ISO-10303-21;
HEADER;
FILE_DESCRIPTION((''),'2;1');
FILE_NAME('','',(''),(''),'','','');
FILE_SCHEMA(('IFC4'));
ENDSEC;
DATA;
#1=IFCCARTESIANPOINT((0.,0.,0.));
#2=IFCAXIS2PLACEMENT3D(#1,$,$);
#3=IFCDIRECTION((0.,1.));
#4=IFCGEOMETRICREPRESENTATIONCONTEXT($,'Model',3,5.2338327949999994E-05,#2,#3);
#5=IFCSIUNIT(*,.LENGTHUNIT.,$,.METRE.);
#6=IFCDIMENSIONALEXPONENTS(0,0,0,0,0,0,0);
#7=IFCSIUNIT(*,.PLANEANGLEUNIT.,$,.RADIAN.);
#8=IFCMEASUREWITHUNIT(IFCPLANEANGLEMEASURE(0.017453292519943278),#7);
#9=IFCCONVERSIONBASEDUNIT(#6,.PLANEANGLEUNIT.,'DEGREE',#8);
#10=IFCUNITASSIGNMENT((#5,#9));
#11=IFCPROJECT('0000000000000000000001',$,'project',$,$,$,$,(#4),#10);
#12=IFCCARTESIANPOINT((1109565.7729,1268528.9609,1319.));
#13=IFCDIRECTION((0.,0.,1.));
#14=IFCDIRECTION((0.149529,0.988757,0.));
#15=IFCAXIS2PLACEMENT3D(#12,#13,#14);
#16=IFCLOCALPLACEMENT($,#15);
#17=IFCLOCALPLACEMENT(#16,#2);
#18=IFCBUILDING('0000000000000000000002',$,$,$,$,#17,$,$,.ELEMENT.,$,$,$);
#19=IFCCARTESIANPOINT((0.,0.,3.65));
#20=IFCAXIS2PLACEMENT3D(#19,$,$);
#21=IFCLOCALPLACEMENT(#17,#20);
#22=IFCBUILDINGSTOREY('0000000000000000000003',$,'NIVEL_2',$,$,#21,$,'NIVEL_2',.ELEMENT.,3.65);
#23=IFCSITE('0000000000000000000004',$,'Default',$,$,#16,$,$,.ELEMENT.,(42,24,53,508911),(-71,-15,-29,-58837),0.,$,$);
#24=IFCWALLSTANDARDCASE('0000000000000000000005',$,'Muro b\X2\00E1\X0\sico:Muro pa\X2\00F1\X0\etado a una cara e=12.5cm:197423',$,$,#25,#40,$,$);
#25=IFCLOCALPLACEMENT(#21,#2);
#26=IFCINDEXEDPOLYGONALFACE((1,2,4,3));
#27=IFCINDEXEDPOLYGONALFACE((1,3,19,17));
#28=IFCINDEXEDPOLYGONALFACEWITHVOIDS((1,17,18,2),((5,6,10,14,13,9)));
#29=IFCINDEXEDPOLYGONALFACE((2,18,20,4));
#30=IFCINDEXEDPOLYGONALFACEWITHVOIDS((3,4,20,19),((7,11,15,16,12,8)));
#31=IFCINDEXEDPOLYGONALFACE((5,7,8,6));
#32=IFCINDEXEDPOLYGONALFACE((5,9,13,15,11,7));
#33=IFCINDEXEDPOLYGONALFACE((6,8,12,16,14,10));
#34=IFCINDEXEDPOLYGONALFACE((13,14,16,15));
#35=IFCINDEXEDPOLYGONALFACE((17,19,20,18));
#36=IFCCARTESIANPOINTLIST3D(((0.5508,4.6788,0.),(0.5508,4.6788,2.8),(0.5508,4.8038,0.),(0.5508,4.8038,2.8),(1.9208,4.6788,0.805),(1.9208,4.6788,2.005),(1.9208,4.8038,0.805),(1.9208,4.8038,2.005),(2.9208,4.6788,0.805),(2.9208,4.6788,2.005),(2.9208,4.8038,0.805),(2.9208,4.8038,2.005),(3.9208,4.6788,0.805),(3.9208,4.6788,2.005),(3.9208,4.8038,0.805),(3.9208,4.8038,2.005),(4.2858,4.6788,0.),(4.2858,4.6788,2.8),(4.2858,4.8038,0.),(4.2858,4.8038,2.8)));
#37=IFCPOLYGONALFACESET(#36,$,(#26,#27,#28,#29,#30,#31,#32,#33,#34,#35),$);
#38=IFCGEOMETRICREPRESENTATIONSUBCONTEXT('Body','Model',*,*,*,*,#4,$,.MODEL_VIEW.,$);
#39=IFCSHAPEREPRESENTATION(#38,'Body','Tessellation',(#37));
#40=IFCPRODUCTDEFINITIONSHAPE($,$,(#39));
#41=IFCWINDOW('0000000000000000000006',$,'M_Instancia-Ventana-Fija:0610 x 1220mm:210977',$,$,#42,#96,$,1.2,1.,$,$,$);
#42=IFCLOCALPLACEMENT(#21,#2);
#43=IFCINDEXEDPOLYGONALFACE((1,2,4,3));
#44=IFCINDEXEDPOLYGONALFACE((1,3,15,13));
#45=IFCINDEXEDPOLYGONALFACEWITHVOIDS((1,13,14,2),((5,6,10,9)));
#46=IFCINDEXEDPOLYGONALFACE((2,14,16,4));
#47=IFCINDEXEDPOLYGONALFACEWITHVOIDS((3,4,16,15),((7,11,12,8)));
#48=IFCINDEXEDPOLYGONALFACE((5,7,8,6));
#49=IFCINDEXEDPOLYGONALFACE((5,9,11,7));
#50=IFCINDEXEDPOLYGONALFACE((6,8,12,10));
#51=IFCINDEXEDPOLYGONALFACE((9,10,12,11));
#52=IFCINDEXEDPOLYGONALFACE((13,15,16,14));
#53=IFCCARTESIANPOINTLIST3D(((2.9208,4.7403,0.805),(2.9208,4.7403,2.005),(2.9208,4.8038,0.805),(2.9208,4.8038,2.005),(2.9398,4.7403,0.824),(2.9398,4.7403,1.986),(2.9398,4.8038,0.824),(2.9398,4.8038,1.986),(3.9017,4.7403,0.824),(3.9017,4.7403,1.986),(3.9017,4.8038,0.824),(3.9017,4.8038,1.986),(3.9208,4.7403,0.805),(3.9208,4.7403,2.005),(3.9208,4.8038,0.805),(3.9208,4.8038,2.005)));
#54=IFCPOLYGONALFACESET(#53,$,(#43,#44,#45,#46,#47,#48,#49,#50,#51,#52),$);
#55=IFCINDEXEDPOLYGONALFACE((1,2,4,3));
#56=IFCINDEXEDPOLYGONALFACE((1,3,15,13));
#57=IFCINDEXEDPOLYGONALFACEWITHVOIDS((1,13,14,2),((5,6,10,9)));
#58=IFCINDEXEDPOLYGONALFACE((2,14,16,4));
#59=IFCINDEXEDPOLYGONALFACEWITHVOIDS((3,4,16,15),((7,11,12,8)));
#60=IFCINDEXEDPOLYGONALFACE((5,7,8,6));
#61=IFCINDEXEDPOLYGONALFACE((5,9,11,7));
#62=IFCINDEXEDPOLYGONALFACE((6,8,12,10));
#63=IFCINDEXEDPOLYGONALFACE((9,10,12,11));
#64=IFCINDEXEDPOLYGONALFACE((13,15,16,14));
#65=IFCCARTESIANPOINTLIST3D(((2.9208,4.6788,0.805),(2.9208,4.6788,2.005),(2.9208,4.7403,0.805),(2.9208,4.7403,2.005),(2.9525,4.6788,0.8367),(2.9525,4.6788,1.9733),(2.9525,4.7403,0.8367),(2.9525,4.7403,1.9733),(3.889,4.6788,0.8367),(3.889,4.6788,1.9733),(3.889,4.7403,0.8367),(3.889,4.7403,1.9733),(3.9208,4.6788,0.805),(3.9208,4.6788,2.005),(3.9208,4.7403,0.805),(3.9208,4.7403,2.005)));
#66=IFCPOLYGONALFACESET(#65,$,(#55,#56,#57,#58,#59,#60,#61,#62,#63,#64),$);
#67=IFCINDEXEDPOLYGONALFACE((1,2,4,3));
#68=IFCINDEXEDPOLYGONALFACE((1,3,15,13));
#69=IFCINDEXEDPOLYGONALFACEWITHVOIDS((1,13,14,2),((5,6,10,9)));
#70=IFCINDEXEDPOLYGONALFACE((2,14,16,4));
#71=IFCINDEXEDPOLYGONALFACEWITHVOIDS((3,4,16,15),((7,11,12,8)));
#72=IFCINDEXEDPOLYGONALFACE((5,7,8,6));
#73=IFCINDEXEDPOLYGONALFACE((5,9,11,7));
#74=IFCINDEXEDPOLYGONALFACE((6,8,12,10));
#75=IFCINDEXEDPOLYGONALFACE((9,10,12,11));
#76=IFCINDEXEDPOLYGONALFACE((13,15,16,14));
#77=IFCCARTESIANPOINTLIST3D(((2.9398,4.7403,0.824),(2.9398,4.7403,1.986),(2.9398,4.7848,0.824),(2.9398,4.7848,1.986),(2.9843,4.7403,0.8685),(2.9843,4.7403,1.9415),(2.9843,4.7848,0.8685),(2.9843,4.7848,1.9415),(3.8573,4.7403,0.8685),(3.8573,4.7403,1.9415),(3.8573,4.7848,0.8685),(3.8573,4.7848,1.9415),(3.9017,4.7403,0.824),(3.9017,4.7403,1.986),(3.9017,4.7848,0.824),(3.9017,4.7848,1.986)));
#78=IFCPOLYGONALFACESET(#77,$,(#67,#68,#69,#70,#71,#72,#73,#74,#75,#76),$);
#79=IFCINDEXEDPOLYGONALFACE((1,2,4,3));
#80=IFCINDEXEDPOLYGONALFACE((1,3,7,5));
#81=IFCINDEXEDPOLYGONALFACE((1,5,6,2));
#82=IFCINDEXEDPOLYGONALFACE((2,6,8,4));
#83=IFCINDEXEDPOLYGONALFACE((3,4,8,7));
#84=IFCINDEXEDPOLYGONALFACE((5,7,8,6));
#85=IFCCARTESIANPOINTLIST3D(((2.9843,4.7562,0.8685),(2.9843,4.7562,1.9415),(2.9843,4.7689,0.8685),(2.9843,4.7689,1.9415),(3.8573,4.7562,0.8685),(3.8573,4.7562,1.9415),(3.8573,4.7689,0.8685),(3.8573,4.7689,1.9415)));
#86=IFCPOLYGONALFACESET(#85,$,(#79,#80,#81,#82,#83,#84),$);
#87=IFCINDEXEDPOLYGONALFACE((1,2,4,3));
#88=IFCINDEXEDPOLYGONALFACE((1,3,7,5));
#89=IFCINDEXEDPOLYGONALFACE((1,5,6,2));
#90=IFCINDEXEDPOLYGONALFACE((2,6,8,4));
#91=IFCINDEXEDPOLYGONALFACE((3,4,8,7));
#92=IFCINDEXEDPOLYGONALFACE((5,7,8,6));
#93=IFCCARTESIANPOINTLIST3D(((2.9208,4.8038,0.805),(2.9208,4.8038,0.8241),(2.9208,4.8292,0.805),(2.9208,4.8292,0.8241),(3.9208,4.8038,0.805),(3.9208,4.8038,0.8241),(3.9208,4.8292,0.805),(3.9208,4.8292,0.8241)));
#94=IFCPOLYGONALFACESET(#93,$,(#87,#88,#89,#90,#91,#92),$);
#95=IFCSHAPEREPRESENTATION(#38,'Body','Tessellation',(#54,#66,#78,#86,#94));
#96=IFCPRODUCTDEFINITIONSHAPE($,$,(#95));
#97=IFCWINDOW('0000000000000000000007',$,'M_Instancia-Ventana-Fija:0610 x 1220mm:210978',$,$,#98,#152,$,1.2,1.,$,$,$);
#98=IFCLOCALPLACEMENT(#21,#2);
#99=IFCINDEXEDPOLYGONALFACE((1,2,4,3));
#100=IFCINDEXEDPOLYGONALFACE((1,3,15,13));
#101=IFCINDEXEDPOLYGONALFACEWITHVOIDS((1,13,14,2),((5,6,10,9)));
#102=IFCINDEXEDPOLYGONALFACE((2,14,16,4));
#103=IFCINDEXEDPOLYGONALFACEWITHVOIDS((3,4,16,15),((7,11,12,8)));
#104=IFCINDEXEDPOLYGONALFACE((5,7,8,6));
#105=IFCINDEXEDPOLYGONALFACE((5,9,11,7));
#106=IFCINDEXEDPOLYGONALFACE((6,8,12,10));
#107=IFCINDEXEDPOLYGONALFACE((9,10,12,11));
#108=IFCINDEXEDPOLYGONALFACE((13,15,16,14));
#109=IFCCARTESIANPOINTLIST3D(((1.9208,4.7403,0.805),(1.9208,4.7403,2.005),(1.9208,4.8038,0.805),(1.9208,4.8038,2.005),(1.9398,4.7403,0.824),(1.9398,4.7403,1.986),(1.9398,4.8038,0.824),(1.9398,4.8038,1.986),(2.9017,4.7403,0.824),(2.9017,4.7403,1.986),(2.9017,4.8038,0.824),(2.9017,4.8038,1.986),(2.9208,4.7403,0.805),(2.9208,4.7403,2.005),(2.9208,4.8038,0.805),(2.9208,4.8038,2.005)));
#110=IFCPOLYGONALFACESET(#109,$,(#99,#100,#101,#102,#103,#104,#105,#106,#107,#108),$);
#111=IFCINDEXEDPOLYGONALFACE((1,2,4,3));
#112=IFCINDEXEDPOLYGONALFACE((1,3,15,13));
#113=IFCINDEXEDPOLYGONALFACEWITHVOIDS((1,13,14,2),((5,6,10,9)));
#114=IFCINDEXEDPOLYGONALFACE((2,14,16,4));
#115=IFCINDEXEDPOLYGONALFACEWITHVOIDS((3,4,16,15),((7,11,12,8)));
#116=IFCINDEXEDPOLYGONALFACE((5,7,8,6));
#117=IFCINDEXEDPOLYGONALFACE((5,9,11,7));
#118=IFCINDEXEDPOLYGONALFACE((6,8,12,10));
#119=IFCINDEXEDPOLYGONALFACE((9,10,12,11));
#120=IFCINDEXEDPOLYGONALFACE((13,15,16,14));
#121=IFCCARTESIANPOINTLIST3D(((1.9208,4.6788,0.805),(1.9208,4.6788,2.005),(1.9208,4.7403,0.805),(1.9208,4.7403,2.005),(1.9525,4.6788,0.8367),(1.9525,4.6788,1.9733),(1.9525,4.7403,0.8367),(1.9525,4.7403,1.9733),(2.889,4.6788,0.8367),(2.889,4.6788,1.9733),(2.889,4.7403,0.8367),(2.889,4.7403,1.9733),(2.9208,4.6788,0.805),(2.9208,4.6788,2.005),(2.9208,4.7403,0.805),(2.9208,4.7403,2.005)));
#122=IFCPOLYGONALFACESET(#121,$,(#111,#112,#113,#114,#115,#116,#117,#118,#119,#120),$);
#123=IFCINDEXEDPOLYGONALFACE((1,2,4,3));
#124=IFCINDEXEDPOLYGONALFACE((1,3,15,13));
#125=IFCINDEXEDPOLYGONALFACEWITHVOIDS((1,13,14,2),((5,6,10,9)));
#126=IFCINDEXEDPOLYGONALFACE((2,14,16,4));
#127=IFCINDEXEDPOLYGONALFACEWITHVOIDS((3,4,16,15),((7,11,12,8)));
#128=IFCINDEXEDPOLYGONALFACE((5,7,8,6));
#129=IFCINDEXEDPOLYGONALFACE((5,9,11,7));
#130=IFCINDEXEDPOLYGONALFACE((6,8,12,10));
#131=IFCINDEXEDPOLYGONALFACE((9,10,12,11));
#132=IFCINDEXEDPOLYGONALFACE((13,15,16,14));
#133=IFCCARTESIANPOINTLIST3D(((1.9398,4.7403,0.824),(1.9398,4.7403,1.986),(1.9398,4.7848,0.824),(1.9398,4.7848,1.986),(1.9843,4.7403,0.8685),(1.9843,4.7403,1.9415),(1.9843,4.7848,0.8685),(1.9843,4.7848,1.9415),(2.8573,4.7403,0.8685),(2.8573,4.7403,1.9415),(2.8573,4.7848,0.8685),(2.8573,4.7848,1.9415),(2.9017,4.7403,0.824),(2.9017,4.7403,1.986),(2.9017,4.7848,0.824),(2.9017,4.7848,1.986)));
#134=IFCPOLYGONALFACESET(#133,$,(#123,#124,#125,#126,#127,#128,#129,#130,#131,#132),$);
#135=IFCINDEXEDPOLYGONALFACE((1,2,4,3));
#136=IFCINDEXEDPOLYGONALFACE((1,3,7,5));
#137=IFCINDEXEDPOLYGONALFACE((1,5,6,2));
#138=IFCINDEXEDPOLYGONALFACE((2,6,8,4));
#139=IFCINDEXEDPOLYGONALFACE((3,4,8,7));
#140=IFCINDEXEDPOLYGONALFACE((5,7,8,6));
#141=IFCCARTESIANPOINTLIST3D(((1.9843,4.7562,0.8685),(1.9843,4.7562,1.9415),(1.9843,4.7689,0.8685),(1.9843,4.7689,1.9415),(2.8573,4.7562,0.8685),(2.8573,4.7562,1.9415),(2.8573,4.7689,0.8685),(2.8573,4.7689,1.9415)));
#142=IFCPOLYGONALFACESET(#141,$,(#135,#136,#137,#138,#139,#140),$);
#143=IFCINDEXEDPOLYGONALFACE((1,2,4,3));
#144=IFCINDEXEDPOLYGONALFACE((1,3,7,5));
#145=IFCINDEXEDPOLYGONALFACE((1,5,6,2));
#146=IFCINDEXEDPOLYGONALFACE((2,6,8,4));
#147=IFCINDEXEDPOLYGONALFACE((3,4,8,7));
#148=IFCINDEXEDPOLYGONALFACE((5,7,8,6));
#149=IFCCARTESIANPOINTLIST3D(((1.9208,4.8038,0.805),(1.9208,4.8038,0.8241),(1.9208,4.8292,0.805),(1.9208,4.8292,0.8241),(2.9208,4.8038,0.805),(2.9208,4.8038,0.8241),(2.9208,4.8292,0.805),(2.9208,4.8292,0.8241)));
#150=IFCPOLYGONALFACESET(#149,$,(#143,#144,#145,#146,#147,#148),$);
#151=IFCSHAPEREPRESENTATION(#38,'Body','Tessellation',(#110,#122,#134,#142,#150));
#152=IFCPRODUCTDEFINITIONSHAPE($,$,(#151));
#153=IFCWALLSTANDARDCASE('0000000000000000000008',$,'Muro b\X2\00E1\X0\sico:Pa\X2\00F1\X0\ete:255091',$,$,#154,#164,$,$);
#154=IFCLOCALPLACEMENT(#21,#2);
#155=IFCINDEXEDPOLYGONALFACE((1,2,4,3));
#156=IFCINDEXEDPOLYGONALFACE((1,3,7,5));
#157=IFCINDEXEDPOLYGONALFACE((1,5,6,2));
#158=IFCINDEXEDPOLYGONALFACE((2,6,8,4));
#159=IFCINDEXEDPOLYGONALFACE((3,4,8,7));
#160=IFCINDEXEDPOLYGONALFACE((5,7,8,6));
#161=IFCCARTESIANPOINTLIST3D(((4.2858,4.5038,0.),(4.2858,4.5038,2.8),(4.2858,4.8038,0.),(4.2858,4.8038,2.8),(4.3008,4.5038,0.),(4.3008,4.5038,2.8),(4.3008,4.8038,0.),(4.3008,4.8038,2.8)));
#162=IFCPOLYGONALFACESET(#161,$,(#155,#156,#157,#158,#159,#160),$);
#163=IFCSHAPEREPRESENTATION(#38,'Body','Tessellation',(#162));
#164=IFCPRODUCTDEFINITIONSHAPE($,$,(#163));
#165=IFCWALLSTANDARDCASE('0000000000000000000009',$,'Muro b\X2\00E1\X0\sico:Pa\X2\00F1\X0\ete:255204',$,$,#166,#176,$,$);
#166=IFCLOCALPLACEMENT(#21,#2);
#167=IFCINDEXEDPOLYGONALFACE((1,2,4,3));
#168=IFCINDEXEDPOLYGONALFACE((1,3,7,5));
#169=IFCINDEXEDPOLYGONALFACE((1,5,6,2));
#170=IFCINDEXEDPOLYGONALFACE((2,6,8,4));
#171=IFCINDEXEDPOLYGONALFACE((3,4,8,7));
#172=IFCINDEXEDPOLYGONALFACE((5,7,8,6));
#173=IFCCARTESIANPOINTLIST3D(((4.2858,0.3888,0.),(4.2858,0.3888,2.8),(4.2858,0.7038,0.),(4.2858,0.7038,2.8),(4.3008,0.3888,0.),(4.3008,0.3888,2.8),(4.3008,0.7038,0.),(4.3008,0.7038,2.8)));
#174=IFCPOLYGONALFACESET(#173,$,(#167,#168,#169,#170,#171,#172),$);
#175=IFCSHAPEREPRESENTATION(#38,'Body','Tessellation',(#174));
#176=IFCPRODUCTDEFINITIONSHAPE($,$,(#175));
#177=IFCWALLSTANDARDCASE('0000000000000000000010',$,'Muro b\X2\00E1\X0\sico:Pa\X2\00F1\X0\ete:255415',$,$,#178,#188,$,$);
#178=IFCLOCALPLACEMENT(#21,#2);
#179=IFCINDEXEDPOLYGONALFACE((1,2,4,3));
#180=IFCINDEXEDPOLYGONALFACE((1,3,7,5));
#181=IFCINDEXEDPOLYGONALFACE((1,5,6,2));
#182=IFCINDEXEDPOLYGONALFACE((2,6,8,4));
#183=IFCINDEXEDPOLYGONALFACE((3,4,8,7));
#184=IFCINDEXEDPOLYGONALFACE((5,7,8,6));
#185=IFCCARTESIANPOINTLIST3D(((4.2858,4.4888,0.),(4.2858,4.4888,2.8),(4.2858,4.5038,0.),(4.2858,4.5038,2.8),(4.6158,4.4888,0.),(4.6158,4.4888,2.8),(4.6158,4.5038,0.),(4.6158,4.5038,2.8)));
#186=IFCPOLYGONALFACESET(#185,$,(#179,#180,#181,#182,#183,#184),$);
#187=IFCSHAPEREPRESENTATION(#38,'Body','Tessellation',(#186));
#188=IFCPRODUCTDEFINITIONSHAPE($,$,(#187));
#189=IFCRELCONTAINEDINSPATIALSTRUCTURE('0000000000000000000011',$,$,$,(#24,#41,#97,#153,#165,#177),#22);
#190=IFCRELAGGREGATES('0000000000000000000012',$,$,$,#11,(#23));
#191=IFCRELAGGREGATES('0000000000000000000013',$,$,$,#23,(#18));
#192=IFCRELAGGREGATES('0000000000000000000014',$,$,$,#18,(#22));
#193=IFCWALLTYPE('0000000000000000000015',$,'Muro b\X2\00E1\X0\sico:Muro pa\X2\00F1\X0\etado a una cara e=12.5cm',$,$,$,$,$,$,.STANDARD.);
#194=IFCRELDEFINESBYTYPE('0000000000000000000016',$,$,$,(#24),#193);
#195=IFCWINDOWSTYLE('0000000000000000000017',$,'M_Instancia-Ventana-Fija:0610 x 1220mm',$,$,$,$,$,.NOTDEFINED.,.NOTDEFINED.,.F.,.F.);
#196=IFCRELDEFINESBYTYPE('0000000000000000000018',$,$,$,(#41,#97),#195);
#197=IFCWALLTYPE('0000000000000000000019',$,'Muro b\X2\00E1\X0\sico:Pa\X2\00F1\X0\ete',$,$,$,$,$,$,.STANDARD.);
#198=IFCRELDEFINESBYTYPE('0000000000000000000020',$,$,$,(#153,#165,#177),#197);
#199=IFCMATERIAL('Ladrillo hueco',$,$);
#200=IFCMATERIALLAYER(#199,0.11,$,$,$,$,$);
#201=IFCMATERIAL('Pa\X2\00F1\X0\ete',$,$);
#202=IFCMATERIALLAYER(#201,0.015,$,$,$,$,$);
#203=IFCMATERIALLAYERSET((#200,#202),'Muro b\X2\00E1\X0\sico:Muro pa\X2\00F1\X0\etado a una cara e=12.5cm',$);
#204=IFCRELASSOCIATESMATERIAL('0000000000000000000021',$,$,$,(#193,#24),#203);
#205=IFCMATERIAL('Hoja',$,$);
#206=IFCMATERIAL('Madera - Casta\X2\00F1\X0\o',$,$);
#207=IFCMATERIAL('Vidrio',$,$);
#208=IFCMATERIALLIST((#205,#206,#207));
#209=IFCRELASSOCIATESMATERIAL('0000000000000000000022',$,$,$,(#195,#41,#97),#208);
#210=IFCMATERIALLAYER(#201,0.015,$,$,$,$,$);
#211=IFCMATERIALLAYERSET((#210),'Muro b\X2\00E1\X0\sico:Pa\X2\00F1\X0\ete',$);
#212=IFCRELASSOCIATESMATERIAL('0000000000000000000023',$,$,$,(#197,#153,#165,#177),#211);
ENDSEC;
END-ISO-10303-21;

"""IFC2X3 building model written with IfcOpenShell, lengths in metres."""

from ifc_helpers import new_model, entity, si_unit, converted_unit, direction, frame, frame_2d, origin, origin_2d_with_axis, place, context, subcontext, project, spatial, polyline, rectangle, outline, extrude, source, transform, mapped, material, material_list, layer, layer_set, layer_usage, type_object, type_shapes, element, fill, save


model = new_model("IFC2X3")

# Units and contexts
model_context = context("Model", 3, precision=5.2338327949999994e-05, world=origin(), true_north=direction((0.0, 1.0)))
body_context = subcontext(model_context, "Body", "Model", "MODEL_VIEW")
ifc_project = project(units=[si_unit("LENGTHUNIT", "METRE"), converted_unit("PLANEANGLEUNIT", "DEGREE", entity("IfcPlaneAngleMeasure", 0.017453292519943278), si_unit("PLANEANGLEUNIT", "RADIAN"), dimensions=[0, 0, 0, 0, 0, 0, 0])], contexts=[model_context])

# Site, building, storey
site_placement = place(None, frame((1109565.7729, 1268528.9609, 1319.0), z_axis=(0.0, 0.0, 1.0), x_axis=(0.149529, 0.988757, 0.0)))
site = spatial("IfcSite", under=ifc_project, at=site_placement, Name="Default", CompositionType="ELEMENT", RefLatitude=(42, 24, 53, 508911), RefLongitude=(-71, -15, -29, -58837), RefElevation=0.0)
building_placement = place(site_placement, origin())
building = spatial("IfcBuilding", under=site, at=building_placement, CompositionType="ELEMENT")
storey_placement = place(building_placement, frame((0.0, 0.0, 3.65)))
storey = spatial("IfcBuildingStorey", under=building, at=storey_placement, Name="NIVEL_2", LongName="NIVEL_2", CompositionType="ELEMENT", Elevation=3.65)

# Shared definitions
ifc_material_1 = material(Name="Pañete")
ifc_material_2 = material(Name="Ladrillo hueco")

# Shared definitions
ifc_layer_1 = layer(ifc_material_2, 0.11)
ifc_layer_2 = layer(ifc_material_1, 0.015)
ifc_layer_set_1 = layer_set([ifc_layer_1, ifc_layer_2], Name="Muro básico:Muro pañetado a una cara e=12.5cm")
wall_type_1 = type_object("IfcWallType", Name="Muro básico:Muro pañetado a una cara e=12.5cm", PredefinedType="STANDARD", material=ifc_layer_set_1)

# Shared definitions
ifc_material_3 = material(Name="Hoja")
ifc_material_4 = material(Name="Madera - Castaño")
ifc_material_5 = material(Name="Vidrio")
ifc_material_list = material_list([ifc_material_3, ifc_material_4, ifc_material_5])

# Wall, openings, windows
ifc_layer_usage_1 = layer_usage(ifc_layer_set_1, "AXIS2", "POSITIVE", -0.0625)
wall_1_placement = place(storey_placement, frame((4.2858, 4.7413, 0.0), z_axis=(0.0, 0.0, 1.0), x_axis=(-1.0, 0.0, 0.0)))
wall_1 = element("IfcWallStandardCase", 1, at=wall_1_placement, inside=storey, type_object=wall_type_1, material=ifc_layer_usage_1, Name="Muro básico:Muro pañetado a una cara e=12.5cm:197423", context=body_context, shape_type="SweptSolid", body=[
    extrude(rectangle(XDim=3.735, YDim=0.125, at=frame_2d((1.8675, 0.0), x_axis=(-1.0, 0.0))), origin(), (0.0, 0.0, 1.0), 2.8),
])
opening_1_placement = place(wall_1_placement, frame((2.365, 0.0625, 0.805)))
opening_1 = element("IfcOpeningElement", 2, at=opening_1_placement, cuts=wall_1, ObjectType="Opening", context=body_context, shape_type="SweptSolid", body=[
    extrude(rectangle(XDim=1.2, YDim=1.0, at=frame_2d((0.6, 0.5), x_axis=(-1.0, 0.0))), frame((0.0, 0.0, 0.0), z_axis=(0.0, -1.0, 0.0), x_axis=(0.0, 0.0, 1.0)), (0.0, 0.0, 1.0), 0.125),
])
opening_2_placement = place(wall_1_placement, frame((1.365, 0.0625, 0.805)))
opening_2 = element("IfcOpeningElement", 3, at=opening_2_placement, cuts=wall_1, ObjectType="Opening", context=body_context, shape_type="SweptSolid", body=[
    extrude(rectangle(XDim=1.2, YDim=1.0, at=frame_2d((0.6, 0.5), x_axis=(-1.0, 0.0))), frame((0.0, 0.0, 0.0), z_axis=(0.0, -1.0, 0.0), x_axis=(0.0, 0.0, 1.0)), (0.0, 0.0, 1.0), 0.125),
])
window_style_1 = type_object("IfcWindowStyle", Name="M_Instancia-Ventana-Fija:0610 x 1220mm", ConstructionType="NOTDEFINED", OperationType="NOTDEFINED", ParameterTakesPrecedence=False, Sizeable=False, material=ifc_material_list)
shared_shape_1 = source(origin(), body_context, "Body", "SweptSolid", [
    extrude(outline(polyline([(-0.6, -0.5), (0.6, -0.5), (0.6, 0.5), (-0.6, 0.5), (-0.6, -0.5)]), holes=[polyline([(-0.5809, -0.4809), (-0.5809, 0.481), (0.581, 0.481), (0.581, -0.4809), (-0.5809, -0.4809)])]), frame((0.5, 0.0616, 0.6), z_axis=(0.0, 1.0, 0.0), x_axis=(0.0, 0.0, -1.0)), (0.0, 0.0, 1.0), 0.0635),
    extrude(outline(polyline([(-0.5, -0.6), (0.5, -0.6), (0.5, 0.6), (-0.5, 0.6), (-0.5, -0.6)]), holes=[polyline([(-0.4683, -0.5682), (-0.4683, 0.5683), (0.4682, 0.5683), (0.4682, -0.5682), (-0.4683, -0.5682)])]), frame((0.5, 0.0, 0.6), z_axis=(0.0, 1.0, 0.0), x_axis=(1.0, 0.0, 0.0)), (0.0, 0.0, 1.0), 0.0616),
    extrude(outline(polyline([(-0.4809, -0.581), (0.4809, -0.581), (0.4809, 0.581), (-0.4809, 0.581), (-0.4809, -0.581)]), holes=[polyline([(-0.4365, -0.5365), (-0.4365, 0.5365), (0.4365, 0.5365), (0.4365, -0.5365), (-0.4365, -0.5365)])]), frame((0.5, 0.0616, 0.6), z_axis=(0.0, 1.0, 0.0), x_axis=(1.0, 0.0, 0.0)), (0.0, 0.0, 1.0), 0.0444),
    extrude(rectangle(XDim=0.0127, YDim=0.873, at=origin_2d_with_axis()), frame((0.5, 0.0838, 0.0635), z_axis=(0.0, 0.0, 1.0), x_axis=(0.0, 1.0, 0.0)), (0.0, 0.0, 1.0), 1.073),
    extrude(rectangle(XDim=0.0254, YDim=1.0, at=origin_2d_with_axis()), frame((0.5, 0.1377, 0.0), z_axis=(0.0, 0.0, 1.0), x_axis=(0.0, -1.0, 0.0)), (0.0, 0.0, 1.0), 0.019),
])
type_shapes(window_style_1, [shared_shape_1])
window_1_placement = place(opening_2_placement, frame((0.0, 0.0, 0.0), z_axis=(0.0, 0.0, 1.0), x_axis=(-1.0, 0.0, 0.0)))
window_1 = element("IfcWindow", 4, at=window_1_placement, inside=storey, type_object=window_style_1, material=ifc_material_list, Name="M_Instancia-Ventana-Fija:0610 x 1220mm:210977", OverallHeight=1.2, OverallWidth=1.0, context=body_context, shape_type="MappedRepresentation", body=[
    mapped(shared_shape_1, transform((0.0, 0.0, 0.0), scale=1.0)),
])
fill(opening_2, window_1)
window_2_placement = place(opening_1_placement, frame((0.0, 0.0, 0.0), z_axis=(0.0, 0.0, 1.0), x_axis=(-1.0, 0.0, 0.0)))
window_2 = element("IfcWindow", 5, at=window_2_placement, inside=storey, type_object=window_style_1, material=ifc_material_list, Name="M_Instancia-Ventana-Fija:0610 x 1220mm:210978", OverallHeight=1.2, OverallWidth=1.0, context=body_context, shape_type="MappedRepresentation", body=[
    mapped(shared_shape_1, transform((0.0, 0.0, 0.0), scale=1.0)),
])
fill(opening_1, window_2)

# Walls
ifc_layer_3 = layer(ifc_material_1, 0.015)
ifc_layer_set_2 = layer_set([ifc_layer_3], Name="Muro básico:Pañete")
ifc_layer_usage_2 = layer_usage(ifc_layer_set_2, "AXIS2", "POSITIVE", -0.0075)
wall_type_2 = type_object("IfcWallType", Name="Muro básico:Pañete", PredefinedType="STANDARD", material=ifc_layer_set_2)
wall_2_placement = place(storey_placement, frame((4.2933, 4.8038, 0.0), z_axis=(0.0, 0.0, 1.0), x_axis=(0.0, -1.0, 0.0)))
element("IfcWallStandardCase", 6, at=wall_2_placement, inside=storey, type_object=wall_type_2, material=ifc_layer_usage_2, Name="Muro básico:Pañete:255091", context=body_context, shape_type="SweptSolid", body=[
    extrude(rectangle(XDim=0.3, YDim=0.015, at=frame_2d((0.15, 0.0), x_axis=(-1.0, 0.0))), origin(), (0.0, 0.0, 1.0), 2.8),
])
ifc_layer_usage_3 = layer_usage(ifc_layer_set_2, "AXIS2", "POSITIVE", -0.0075)
wall_3_placement = place(storey_placement, frame((4.2933, 0.7038, 0.0), z_axis=(0.0, 0.0, 1.0), x_axis=(0.0, -1.0, 0.0)))
element("IfcWallStandardCase", 7, at=wall_3_placement, inside=storey, type_object=wall_type_2, material=ifc_layer_usage_3, Name="Muro básico:Pañete:255204", context=body_context, shape_type="SweptSolid", body=[
    extrude(rectangle(XDim=0.315, YDim=0.015, at=frame_2d((0.1575, 0.0), x_axis=(-1.0, 0.0))), origin(), (0.0, 0.0, 1.0), 2.8),
])
ifc_layer_usage_4 = layer_usage(ifc_layer_set_2, "AXIS2", "POSITIVE", -0.0075)
wall_4_placement = place(storey_placement, frame((4.2858, 4.4963, 0.0)))
element("IfcWallStandardCase", 8, at=wall_4_placement, inside=storey, type_object=wall_type_2, material=ifc_layer_usage_4, Name="Muro básico:Pañete:255415", context=body_context, shape_type="SweptSolid", body=[
    extrude(rectangle(XDim=0.33, YDim=0.015, at=frame_2d((0.165, 0.0), x_axis=(-1.0, 0.0))), origin(), (0.0, 0.0, 1.0), 2.8),
])

save(model, "model.ifc")
